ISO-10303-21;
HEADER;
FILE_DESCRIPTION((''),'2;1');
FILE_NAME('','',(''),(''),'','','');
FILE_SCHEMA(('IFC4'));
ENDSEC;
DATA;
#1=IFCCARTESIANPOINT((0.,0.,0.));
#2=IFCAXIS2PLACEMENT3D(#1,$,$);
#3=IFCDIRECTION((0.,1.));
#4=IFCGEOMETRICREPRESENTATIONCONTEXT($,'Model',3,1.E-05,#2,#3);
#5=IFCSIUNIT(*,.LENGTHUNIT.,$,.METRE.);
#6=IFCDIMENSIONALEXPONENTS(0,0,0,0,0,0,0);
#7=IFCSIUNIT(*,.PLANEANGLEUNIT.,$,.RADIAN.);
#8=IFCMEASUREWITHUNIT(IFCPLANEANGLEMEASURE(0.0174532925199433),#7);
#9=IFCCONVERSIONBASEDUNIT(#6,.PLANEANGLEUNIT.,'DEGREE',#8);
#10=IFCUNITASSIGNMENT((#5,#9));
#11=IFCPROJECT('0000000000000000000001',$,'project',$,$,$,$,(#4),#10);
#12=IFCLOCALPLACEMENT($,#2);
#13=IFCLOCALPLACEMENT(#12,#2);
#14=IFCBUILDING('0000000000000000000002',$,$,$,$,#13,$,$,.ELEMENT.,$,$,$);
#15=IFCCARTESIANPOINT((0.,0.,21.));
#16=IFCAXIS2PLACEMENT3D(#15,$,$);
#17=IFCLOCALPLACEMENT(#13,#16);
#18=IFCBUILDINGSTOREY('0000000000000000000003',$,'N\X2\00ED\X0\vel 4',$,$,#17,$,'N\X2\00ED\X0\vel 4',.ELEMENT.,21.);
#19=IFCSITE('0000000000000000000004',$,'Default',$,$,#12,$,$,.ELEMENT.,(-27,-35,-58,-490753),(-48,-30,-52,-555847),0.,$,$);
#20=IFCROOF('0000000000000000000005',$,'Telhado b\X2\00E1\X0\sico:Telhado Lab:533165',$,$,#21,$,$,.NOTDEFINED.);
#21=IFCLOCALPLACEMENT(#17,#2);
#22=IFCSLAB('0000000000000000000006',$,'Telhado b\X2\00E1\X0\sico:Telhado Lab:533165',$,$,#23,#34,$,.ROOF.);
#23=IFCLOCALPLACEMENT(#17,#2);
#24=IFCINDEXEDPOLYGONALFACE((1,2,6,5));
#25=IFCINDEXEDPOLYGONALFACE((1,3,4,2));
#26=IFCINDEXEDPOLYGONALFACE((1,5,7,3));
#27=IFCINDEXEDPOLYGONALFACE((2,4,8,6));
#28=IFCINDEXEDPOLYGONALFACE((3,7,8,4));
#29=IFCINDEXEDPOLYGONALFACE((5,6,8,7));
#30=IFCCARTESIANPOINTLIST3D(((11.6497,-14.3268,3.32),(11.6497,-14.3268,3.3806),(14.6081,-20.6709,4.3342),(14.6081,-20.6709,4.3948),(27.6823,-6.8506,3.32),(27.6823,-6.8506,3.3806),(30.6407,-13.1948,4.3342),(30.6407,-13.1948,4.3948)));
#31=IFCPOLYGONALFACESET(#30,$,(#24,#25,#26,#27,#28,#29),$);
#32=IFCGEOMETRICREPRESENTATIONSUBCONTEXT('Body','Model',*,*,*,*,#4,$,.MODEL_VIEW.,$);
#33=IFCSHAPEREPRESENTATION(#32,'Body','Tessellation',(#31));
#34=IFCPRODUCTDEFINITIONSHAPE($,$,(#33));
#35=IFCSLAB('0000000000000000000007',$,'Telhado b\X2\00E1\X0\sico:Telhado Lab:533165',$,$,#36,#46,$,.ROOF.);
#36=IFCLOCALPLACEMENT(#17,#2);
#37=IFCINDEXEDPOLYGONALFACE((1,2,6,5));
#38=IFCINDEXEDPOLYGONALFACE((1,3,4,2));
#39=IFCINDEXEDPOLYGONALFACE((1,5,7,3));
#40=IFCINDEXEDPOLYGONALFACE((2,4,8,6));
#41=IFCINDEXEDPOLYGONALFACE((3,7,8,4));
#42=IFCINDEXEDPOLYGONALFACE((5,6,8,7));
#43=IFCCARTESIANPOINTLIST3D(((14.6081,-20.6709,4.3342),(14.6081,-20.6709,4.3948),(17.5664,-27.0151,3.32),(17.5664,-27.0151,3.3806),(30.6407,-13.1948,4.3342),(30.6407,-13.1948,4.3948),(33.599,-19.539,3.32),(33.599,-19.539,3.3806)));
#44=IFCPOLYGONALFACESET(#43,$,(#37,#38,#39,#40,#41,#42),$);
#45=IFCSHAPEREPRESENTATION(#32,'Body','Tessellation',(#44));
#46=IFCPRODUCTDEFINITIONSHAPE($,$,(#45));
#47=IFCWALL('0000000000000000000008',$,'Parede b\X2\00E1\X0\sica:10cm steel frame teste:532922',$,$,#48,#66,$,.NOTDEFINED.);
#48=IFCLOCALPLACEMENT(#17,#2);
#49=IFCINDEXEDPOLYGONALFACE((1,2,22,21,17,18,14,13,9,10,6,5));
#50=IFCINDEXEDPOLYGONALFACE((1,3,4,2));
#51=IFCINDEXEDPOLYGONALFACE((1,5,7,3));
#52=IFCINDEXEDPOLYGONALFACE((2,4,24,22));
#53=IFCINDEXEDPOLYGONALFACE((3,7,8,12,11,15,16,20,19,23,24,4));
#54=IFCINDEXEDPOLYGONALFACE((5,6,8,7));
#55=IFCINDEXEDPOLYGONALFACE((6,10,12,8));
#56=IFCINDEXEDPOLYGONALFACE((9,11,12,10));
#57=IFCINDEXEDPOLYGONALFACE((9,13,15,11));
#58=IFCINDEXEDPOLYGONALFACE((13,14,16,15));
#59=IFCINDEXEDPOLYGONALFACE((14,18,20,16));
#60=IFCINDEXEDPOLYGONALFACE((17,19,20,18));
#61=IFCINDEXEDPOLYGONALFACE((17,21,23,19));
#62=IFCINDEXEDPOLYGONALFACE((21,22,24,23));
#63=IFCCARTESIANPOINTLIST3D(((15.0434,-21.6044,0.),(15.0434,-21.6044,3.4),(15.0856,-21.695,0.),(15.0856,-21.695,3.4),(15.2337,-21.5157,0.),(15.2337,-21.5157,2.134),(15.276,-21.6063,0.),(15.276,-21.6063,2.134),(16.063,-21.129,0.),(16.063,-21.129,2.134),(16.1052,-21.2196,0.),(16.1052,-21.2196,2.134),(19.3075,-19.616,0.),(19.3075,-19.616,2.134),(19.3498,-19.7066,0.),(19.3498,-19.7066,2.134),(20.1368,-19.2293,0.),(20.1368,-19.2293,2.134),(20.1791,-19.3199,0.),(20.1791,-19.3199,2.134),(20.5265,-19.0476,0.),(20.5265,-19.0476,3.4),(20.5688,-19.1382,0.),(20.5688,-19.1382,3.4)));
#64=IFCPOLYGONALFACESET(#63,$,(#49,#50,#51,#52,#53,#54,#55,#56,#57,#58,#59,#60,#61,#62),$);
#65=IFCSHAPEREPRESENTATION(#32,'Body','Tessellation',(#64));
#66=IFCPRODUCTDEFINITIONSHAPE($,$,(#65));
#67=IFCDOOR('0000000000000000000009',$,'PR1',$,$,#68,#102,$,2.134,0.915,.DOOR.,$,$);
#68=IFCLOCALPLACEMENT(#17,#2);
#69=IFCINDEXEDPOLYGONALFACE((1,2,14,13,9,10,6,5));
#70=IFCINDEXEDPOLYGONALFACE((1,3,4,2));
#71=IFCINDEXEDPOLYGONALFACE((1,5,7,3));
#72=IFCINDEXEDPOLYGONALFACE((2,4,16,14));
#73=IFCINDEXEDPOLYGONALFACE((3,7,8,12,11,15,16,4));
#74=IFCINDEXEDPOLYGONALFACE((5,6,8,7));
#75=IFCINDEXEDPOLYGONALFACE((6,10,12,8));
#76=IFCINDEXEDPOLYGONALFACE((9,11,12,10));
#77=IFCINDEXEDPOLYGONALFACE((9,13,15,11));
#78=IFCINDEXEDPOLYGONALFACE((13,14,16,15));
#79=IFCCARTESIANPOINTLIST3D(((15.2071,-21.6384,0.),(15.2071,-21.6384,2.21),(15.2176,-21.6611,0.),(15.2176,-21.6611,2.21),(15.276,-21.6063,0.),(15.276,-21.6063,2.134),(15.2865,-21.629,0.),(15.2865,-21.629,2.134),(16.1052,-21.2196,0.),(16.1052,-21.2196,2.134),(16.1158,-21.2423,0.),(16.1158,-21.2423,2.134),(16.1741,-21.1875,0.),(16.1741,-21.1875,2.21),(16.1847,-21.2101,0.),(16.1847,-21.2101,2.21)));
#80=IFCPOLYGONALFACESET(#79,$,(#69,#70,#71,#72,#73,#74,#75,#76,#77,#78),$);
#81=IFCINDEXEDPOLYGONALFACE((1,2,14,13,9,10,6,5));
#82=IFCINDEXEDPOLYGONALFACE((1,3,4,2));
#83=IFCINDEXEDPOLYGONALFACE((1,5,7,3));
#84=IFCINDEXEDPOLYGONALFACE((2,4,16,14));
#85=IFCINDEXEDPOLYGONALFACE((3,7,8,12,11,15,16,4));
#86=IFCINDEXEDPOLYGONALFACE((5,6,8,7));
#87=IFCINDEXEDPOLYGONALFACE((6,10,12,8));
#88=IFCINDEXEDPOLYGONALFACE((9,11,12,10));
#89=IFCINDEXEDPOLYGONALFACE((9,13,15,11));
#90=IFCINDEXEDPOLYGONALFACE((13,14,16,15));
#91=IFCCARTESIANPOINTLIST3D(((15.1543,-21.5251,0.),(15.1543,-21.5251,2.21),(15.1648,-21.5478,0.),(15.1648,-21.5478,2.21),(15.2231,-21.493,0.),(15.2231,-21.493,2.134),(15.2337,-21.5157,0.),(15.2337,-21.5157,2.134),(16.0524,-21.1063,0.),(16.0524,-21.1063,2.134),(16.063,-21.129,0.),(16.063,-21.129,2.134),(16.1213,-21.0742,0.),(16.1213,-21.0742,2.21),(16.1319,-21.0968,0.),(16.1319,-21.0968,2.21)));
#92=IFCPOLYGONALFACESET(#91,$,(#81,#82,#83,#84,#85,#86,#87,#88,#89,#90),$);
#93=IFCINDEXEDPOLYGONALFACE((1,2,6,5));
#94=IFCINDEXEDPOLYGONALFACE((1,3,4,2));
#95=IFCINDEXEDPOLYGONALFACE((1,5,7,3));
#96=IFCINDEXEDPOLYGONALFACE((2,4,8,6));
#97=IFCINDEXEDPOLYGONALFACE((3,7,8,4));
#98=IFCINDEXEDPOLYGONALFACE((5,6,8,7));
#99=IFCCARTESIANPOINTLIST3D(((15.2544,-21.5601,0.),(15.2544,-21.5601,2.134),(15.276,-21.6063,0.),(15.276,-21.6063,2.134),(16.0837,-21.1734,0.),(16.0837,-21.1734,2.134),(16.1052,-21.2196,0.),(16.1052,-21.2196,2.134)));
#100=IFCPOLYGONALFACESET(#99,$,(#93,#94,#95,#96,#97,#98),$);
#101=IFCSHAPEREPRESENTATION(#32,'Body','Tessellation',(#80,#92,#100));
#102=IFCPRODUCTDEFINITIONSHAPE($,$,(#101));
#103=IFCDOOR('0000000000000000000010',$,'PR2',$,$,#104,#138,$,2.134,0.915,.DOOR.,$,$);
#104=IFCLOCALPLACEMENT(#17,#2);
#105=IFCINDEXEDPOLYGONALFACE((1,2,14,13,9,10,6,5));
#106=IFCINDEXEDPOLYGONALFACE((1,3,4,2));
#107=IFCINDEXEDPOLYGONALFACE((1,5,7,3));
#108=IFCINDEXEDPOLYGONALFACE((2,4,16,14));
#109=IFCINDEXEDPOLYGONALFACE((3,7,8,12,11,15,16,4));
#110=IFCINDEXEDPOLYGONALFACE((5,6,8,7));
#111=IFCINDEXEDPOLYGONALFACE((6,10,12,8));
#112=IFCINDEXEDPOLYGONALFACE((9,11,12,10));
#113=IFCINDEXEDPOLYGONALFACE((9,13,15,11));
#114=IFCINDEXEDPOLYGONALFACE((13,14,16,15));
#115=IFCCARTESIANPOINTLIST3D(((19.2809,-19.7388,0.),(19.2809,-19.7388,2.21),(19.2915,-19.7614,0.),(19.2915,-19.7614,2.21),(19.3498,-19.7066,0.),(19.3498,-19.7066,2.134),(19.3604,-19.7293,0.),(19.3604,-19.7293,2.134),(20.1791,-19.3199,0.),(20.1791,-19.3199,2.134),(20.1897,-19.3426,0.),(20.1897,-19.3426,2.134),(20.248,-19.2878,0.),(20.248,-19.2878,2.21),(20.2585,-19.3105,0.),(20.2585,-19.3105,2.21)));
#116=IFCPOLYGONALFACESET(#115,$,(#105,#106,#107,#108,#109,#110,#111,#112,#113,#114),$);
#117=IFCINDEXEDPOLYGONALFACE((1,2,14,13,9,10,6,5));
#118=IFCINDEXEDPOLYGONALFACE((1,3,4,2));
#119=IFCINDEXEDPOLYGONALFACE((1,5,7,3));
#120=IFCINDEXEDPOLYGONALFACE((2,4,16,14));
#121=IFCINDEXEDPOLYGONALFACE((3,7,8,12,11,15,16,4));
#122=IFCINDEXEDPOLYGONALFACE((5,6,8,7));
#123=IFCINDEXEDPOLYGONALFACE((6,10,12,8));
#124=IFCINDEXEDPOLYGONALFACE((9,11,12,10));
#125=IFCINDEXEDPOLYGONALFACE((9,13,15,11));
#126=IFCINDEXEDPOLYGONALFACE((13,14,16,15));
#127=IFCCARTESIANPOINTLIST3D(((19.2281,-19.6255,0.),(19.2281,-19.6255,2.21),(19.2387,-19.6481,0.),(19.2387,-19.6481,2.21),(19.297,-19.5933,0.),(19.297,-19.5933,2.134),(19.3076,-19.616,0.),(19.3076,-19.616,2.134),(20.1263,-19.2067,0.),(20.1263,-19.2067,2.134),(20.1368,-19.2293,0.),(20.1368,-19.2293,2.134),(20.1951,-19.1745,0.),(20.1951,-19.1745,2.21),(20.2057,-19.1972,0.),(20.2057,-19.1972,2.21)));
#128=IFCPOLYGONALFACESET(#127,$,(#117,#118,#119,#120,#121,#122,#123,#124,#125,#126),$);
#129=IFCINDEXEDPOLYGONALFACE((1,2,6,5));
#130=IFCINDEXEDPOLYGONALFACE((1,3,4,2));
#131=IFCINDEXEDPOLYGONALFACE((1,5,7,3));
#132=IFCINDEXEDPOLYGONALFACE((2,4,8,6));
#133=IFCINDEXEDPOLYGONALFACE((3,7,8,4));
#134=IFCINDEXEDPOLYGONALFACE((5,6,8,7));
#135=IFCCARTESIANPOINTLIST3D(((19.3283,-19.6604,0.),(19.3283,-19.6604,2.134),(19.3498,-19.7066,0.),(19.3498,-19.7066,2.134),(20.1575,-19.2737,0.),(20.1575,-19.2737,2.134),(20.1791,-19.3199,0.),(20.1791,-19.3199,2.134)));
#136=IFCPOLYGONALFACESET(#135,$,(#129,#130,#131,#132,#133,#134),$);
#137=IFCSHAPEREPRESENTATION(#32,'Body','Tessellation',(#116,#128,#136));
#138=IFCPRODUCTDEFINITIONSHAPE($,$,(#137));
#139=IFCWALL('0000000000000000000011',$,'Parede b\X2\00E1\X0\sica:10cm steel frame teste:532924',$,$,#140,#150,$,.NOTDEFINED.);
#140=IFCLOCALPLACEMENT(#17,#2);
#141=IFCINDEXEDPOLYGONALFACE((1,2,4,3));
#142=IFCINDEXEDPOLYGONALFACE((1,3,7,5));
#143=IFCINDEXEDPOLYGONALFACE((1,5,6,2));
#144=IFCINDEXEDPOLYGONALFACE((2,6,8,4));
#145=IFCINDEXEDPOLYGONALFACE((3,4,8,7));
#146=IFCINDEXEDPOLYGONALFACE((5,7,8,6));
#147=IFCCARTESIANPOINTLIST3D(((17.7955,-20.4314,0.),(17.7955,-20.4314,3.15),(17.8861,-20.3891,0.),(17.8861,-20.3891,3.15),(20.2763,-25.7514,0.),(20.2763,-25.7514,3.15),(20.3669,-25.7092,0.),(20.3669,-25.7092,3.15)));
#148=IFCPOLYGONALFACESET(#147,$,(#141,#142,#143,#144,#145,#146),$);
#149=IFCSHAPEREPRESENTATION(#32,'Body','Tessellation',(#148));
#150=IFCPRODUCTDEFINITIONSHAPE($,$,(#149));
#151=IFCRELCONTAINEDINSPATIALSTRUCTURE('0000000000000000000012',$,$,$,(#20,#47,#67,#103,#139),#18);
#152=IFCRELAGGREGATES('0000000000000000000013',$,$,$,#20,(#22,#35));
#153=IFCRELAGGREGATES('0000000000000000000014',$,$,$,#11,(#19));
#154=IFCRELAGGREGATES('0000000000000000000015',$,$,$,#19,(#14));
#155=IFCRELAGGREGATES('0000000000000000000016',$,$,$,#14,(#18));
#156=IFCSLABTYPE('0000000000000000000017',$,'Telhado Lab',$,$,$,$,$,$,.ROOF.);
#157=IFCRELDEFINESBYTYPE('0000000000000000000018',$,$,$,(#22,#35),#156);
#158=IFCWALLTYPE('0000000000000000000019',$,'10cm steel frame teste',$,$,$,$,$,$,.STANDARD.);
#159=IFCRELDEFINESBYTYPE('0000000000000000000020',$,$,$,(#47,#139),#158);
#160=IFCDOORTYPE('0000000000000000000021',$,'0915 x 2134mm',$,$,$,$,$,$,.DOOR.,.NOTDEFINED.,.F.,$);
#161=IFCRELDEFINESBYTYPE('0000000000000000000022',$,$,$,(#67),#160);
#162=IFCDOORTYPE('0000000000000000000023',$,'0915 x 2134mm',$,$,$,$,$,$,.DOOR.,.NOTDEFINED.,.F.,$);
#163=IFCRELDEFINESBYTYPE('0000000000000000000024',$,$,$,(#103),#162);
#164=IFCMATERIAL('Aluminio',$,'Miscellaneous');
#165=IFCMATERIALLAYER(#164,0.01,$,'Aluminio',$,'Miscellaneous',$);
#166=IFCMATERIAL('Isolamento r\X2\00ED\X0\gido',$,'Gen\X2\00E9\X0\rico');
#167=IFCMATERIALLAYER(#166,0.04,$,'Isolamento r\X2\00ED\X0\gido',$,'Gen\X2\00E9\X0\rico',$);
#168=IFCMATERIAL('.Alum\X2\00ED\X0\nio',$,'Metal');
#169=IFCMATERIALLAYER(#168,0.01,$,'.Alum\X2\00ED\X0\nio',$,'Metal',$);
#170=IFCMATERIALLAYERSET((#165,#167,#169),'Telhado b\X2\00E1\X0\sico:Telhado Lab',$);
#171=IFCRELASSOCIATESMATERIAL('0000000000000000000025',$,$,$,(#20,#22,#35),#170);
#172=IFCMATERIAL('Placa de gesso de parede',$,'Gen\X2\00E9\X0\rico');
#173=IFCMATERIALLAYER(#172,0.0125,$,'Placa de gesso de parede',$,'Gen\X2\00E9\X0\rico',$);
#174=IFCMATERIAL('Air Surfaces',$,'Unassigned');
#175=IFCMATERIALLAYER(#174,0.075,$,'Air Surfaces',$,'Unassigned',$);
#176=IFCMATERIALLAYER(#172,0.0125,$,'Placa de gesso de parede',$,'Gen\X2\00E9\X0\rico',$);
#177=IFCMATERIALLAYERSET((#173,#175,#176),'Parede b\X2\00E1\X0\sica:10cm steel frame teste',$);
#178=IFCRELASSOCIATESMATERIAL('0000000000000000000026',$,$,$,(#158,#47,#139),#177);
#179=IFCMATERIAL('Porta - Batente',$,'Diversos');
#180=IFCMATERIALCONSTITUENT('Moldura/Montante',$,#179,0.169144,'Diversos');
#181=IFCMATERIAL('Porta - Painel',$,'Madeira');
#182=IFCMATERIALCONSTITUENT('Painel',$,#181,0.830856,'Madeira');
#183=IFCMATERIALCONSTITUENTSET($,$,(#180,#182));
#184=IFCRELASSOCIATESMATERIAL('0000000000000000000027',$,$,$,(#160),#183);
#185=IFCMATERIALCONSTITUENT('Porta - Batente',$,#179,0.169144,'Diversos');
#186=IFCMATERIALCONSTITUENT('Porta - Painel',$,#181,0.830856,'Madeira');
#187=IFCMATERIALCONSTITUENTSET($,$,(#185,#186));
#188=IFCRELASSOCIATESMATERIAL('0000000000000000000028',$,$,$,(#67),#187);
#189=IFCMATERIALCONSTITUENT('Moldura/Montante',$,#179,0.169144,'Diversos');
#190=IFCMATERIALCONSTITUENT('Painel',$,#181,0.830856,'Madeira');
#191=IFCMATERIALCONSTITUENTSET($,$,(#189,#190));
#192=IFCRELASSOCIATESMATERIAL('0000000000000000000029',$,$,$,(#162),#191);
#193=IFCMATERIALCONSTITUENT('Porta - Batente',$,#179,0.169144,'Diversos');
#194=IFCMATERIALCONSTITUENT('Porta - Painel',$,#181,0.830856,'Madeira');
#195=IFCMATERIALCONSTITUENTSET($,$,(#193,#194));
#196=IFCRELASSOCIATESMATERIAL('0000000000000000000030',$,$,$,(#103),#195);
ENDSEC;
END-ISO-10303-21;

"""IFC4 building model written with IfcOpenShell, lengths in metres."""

from ifc_helpers import new_model, entity, si_unit, converted_unit, direction, frame, frame_2d, origin, origin_with_axes, origin_2d_with_axis, place, context, subcontext, project, spatial, polyline, rectangle, outline, extrude, source, transform, mapped, material, layer, layer_set, layer_usage, constituent, constituent_set, type_object, type_shapes, element, fill, aggregate, save


model = new_model("IFC4")

# Units and contexts
model_context = context("Model", 3, precision=1e-05, world=origin(), true_north=direction((0.0, 1.0)))
body_context = subcontext(model_context, "Body", "Model", "MODEL_VIEW")
ifc_project = project(units=[si_unit("LENGTHUNIT", "METRE"), converted_unit("PLANEANGLEUNIT", "DEGREE", entity("IfcPlaneAngleMeasure", 0.0174532925199433), si_unit("PLANEANGLEUNIT", "RADIAN"), dimensions=[0, 0, 0, 0, 0, 0, 0])], contexts=[model_context])

# Site, building, storey
site_placement = place(None, origin())
site = spatial("IfcSite", under=ifc_project, at=site_placement, Name="Default", CompositionType="ELEMENT", RefLatitude=(-27, -35, -58, -490753), RefLongitude=(-48, -30, -52, -555847), RefElevation=0.0)
building_placement = place(site_placement, origin())
building = spatial("IfcBuilding", under=site, at=building_placement, CompositionType="ELEMENT")
storey_placement = place(building_placement, frame((0.0, 0.0, 21.0)))
storey = spatial("IfcBuildingStorey", under=building, at=storey_placement, Name="Nível 4", LongName="Nível 4", CompositionType="ELEMENT", Elevation=21.0)

# Roof, slabs
ifc_material_1 = material(Name="Aluminio", Category="Miscellaneous")
ifc_layer_1 = layer(ifc_material_1, 0.01, Name="Aluminio", Category="Miscellaneous")
ifc_material_2 = material(Name="Isolamento rígido", Category="Genérico")
ifc_layer_2 = layer(ifc_material_2, 0.04, Name="Isolamento rígido", Category="Genérico")
ifc_material_3 = material(Name=".Alumínio", Category="Metal")
ifc_layer_3 = layer(ifc_material_3, 0.01, Name=".Alumínio", Category="Metal")
ifc_layer_set_1 = layer_set([ifc_layer_1, ifc_layer_2, ifc_layer_3], Name="Telhado básico:Telhado Lab")
roof_placement = place(storey_placement, frame((11.6497, -27.0151, 3.32), z_axis=(0.0, 0.0, 1.0), x_axis=(1.0, 0.0, 0.0)))
roof = element("IfcRoof", 1, at=roof_placement, inside=storey, material=ifc_layer_set_1, Name="Telhado básico:Telhado Lab:533165", PredefinedType="NOTDEFINED")
slab_type_1 = type_object("IfcSlabType", Name="Telhado Lab", PredefinedType="ROOF")
slab_1_placement = place(roof_placement, origin_with_axes())
slab_1 = element("IfcSlab", 2, at=slab_1_placement, type_object=slab_type_1, material=ifc_layer_set_1, Name="Telhado básico:Telhado Lab:533165", PredefinedType="ROOF", context=body_context, shape_type="SweptSolid", body=[
    extrude(rectangle(XDim=17.69, YDim=7.0731, at=frame_2d((0.0, 0.0), x_axis=(0.907976, 0.419021))), frame((9.4955, 13.2543, 0.5071), z_axis=(-0.060597, 0.129951, 0.989667), x_axis=(0.998162, 0.007889, 0.060082)), (0.060082, -0.130191, 0.989667), 0.0606),
])
slab_2_placement = place(roof_placement, origin_with_axes())
slab_2 = element("IfcSlab", 3, at=slab_2_placement, type_object=slab_type_1, material=ifc_layer_set_1, Name="Telhado básico:Telhado Lab:533165", PredefinedType="ROOF", context=body_context, shape_type="SweptSolid", body=[
    extrude(rectangle(XDim=7.0731, YDim=17.69, at=frame_2d((0.0, 0.0), x_axis=(-0.419021, 0.907976))), frame((12.4538, 6.9101, 0.5071), z_axis=(0.060597, -0.129951, 0.989667), x_axis=(0.998162, 0.007889, -0.060082)), (-0.060082, 0.130191, 0.989667), 0.0606),
])
aggregate(roof, [slab_1, slab_2])

# Wall, openings, doors
ifc_material_4 = material(Name="Placa de gesso de parede", Category="Genérico")
ifc_layer_4 = layer(ifc_material_4, 0.0125, Name="Placa de gesso de parede", Category="Genérico")
ifc_material_5 = material(Name="Air Surfaces", Category="Unassigned")
ifc_layer_5 = layer(ifc_material_5, 0.075, Name="Air Surfaces", Category="Unassigned")
ifc_layer_6 = layer(ifc_material_4, 0.0125, Name="Placa de gesso de parede", Category="Genérico")
ifc_layer_set_2 = layer_set([ifc_layer_4, ifc_layer_5, ifc_layer_6], Name="Parede básica:10cm steel frame teste")
ifc_layer_usage_1 = layer_usage(ifc_layer_set_2, "AXIS2", "NEGATIVE", 0.05)
wall_type = type_object("IfcWallType", Name="10cm steel frame teste", PredefinedType="STANDARD", material=ifc_layer_set_2)
wall_1_placement = place(storey_placement, frame((15.0645, -21.6497, 0.0), z_axis=(0.0, 0.0, 1.0), x_axis=(0.906308, 0.422618, 0.0)))
wall_1 = element("IfcWall", 4, at=wall_1_placement, inside=storey, type_object=wall_type, material=ifc_layer_usage_1, Name="Parede básica:10cm steel frame teste:532922", PredefinedType="NOTDEFINED", context=body_context, shape_type="SweptSolid", body=[
    extrude(rectangle(XDim=6.05, YDim=0.1, at=frame_2d((3.025, 0.0), x_axis=(1.0, 0.0))), origin(), (0.0, 0.0, 1.0), 3.4),
])
opening_1_placement = place(wall_1_placement, frame((1.125, 0.05, 0.0)))
opening_1 = element("IfcOpeningElement", 5, at=opening_1_placement, cuts=wall_1, PredefinedType="OPENING", context=body_context, shape_type="SweptSolid", body=[
    extrude(rectangle(XDim=0.915, YDim=2.134, at=frame_2d((1.067, 0.4575), x_axis=(0.0, 1.0))), frame((0.0, 0.0, 0.0), z_axis=(0.0, -1.0, 0.0), x_axis=(0.0, 0.0, 1.0)), (0.0, 0.0, 1.0), 0.1),
])
opening_2_placement = place(wall_1_placement, frame((5.62, 0.05, 0.0)))
opening_2 = element("IfcOpeningElement", 6, at=opening_2_placement, cuts=wall_1, PredefinedType="OPENING", context=body_context, shape_type="SweptSolid", body=[
    extrude(rectangle(XDim=0.915, YDim=2.134, at=frame_2d((1.067, 0.4575), x_axis=(0.0, -1.0))), frame((0.0, 0.0, 0.0), z_axis=(0.0, -1.0, 0.0), x_axis=(0.0, 0.0, 1.0)), (0.0, 0.0, 1.0), 0.1),
])
ifc_material_6 = material(Name="Porta - Batente", Category="Diversos")
ifc_constituent_1 = constituent(ifc_material_6, Name="Porta - Batente", Category="Diversos", fraction=0.169144)
ifc_material_7 = material(Name="Porta - Painel", Category="Madeira")
ifc_constituent_2 = constituent(ifc_material_7, Name="Porta - Painel", Category="Madeira", fraction=0.830856)
ifc_constituent_set_1 = constituent_set(constituents=[ifc_constituent_1, ifc_constituent_2])
ifc_constituent_3 = constituent(ifc_material_6, Name="Moldura/Montante", Category="Diversos", fraction=0.169144)
ifc_constituent_4 = constituent(ifc_material_7, Name="Painel", Category="Madeira", fraction=0.830856)
ifc_constituent_set_2 = constituent_set(constituents=[ifc_constituent_3, ifc_constituent_4])
door_type_1 = type_object("IfcDoorType", Name="0915 x 2134mm", OperationType="NOTDEFINED", ParameterTakesPrecedence=False, PredefinedType="DOOR", material=ifc_constituent_set_2)
shared_shape_1 = source(origin(), body_context, "Body", "SweptSolid", [
    extrude(outline(polyline([(-0.5335, -1.124), (0.5335, -1.124), (0.5335, 1.086), (0.4575, 1.086), (0.4575, -1.048), (-0.4575, -1.048), (-0.4575, 1.086), (-0.5335, 1.086), (-0.5335, -1.124)])), frame((0.4575, 0.1, 1.086), z_axis=(0.0, 1.0, 0.0), x_axis=(1.0, 0.0, 0.0)), (0.0, 0.0, 1.0), 0.025),
    extrude(outline(polyline([(-1.124, -0.5335), (1.086, -0.5335), (1.086, -0.4575), (-1.048, -0.4575), (-1.048, 0.4575), (1.086, 0.4575), (1.086, 0.5335), (-1.124, 0.5335), (-1.124, -0.5335)])), frame((0.4575, -0.025, 1.086), z_axis=(0.0, 1.0, 0.0), x_axis=(0.0, 0.0, -1.0)), (0.0, 0.0, 1.0), 0.025),
    extrude(rectangle(XDim=0.051, YDim=0.915, at=origin_2d_with_axis()), frame((0.4575, 0.0745, 0.0), z_axis=(0.0, 0.0, 1.0), x_axis=(0.0, 1.0, 0.0)), (0.0, 0.0, 1.0), 2.134),
])
type_shapes(door_type_1, [shared_shape_1])
door_1_placement = place(opening_1_placement, frame((0.0, 0.0, 0.0), z_axis=(0.0, 0.0, 1.0), x_axis=(-1.0, 0.0, 0.0)))
door_1 = element("IfcDoor", 7, at=door_1_placement, inside=storey, type_object=door_type_1, material=ifc_constituent_set_1, Name="PR1", OverallHeight=2.134, OverallWidth=0.915, PredefinedType="DOOR", context=body_context, shape_type="MappedRepresentation", body=[
    mapped(shared_shape_1, transform((0.0, 0.0, 0.0), scale=1.0)),
])
fill(opening_1, door_1)
ifc_constituent_5 = constituent(ifc_material_6, Name="Porta - Batente", Category="Diversos", fraction=0.169144)
ifc_constituent_6 = constituent(ifc_material_7, Name="Porta - Painel", Category="Madeira", fraction=0.830856)
ifc_constituent_set_3 = constituent_set(constituents=[ifc_constituent_5, ifc_constituent_6])
ifc_constituent_7 = constituent(ifc_material_6, Name="Moldura/Montante", Category="Diversos", fraction=0.169144)
ifc_constituent_8 = constituent(ifc_material_7, Name="Painel", Category="Madeira", fraction=0.830856)
ifc_constituent_set_4 = constituent_set(constituents=[ifc_constituent_7, ifc_constituent_8])
door_type_2 = type_object("IfcDoorType", Name="0915 x 2134mm", OperationType="NOTDEFINED", ParameterTakesPrecedence=False, PredefinedType="DOOR", material=ifc_constituent_set_4)
shared_shape_2 = source(origin(), body_context, "Body", "SweptSolid", [
    extrude(outline(polyline([(-0.5335, -1.124), (0.5335, -1.124), (0.5335, 1.086), (0.4575, 1.086), (0.4575, -1.048), (-0.4575, -1.048), (-0.4575, 1.086), (-0.5335, 1.086), (-0.5335, -1.124)])), frame((0.4575, 0.125, 1.086), z_axis=(0.0, -1.0, 0.0), x_axis=(-1.0, 0.0, 0.0)), (0.0, 0.0, 1.0), 0.025),
    extrude(outline(polyline([(-1.124, -0.5335), (1.086, -0.5335), (1.086, -0.4575), (-1.048, -0.4575), (-1.048, 0.4575), (1.086, 0.4575), (1.086, 0.5335), (-1.124, 0.5335), (-1.124, -0.5335)])), frame((0.4575, 0.0, 1.086), z_axis=(0.0, -1.0, 0.0), x_axis=(0.0, 0.0, -1.0)), (0.0, 0.0, 1.0), 0.025),
    extrude(rectangle(XDim=0.915, YDim=0.051, at=origin_2d_with_axis()), frame((0.4575, 0.0745, 0.0)), (0.0, 0.0, 1.0), 2.134),
])
type_shapes(door_type_2, [shared_shape_2])
door_2_placement = place(opening_2_placement, frame((0.0, 0.0, 0.0), z_axis=(0.0, 0.0, 1.0), x_axis=(-1.0, 0.0, 0.0)))
door_2 = element("IfcDoor", 8, at=door_2_placement, inside=storey, type_object=door_type_2, material=ifc_constituent_set_3, Name="PR2", OverallHeight=2.134, OverallWidth=0.915, PredefinedType="DOOR", context=body_context, shape_type="MappedRepresentation", body=[
    mapped(shared_shape_2, transform((0.0, 0.0, 0.0), scale=1.0)),
])
fill(opening_2, door_2)

# Wall
ifc_layer_usage_2 = layer_usage(ifc_layer_set_2, "AXIS2", "NEGATIVE", 0.05)
wall_2_placement = place(storey_placement, frame((17.8408, -20.4103, 0.0), z_axis=(0.0, 0.0, 1.0), x_axis=(0.422618, -0.906308, 0.0)))
element("IfcWall", 9, at=wall_2_placement, inside=storey, type_object=wall_type, material=ifc_layer_usage_2, Name="Parede básica:10cm steel frame teste:532924", PredefinedType="NOTDEFINED", context=body_context, shape_type="SweptSolid", body=[
    extrude(rectangle(XDim=5.87, YDim=0.1, at=frame_2d((2.935, 0.0), x_axis=(-1.0, 0.0))), origin(), (0.0, 0.0, 1.0), 3.15),
])

save(model, "model.ifc")
